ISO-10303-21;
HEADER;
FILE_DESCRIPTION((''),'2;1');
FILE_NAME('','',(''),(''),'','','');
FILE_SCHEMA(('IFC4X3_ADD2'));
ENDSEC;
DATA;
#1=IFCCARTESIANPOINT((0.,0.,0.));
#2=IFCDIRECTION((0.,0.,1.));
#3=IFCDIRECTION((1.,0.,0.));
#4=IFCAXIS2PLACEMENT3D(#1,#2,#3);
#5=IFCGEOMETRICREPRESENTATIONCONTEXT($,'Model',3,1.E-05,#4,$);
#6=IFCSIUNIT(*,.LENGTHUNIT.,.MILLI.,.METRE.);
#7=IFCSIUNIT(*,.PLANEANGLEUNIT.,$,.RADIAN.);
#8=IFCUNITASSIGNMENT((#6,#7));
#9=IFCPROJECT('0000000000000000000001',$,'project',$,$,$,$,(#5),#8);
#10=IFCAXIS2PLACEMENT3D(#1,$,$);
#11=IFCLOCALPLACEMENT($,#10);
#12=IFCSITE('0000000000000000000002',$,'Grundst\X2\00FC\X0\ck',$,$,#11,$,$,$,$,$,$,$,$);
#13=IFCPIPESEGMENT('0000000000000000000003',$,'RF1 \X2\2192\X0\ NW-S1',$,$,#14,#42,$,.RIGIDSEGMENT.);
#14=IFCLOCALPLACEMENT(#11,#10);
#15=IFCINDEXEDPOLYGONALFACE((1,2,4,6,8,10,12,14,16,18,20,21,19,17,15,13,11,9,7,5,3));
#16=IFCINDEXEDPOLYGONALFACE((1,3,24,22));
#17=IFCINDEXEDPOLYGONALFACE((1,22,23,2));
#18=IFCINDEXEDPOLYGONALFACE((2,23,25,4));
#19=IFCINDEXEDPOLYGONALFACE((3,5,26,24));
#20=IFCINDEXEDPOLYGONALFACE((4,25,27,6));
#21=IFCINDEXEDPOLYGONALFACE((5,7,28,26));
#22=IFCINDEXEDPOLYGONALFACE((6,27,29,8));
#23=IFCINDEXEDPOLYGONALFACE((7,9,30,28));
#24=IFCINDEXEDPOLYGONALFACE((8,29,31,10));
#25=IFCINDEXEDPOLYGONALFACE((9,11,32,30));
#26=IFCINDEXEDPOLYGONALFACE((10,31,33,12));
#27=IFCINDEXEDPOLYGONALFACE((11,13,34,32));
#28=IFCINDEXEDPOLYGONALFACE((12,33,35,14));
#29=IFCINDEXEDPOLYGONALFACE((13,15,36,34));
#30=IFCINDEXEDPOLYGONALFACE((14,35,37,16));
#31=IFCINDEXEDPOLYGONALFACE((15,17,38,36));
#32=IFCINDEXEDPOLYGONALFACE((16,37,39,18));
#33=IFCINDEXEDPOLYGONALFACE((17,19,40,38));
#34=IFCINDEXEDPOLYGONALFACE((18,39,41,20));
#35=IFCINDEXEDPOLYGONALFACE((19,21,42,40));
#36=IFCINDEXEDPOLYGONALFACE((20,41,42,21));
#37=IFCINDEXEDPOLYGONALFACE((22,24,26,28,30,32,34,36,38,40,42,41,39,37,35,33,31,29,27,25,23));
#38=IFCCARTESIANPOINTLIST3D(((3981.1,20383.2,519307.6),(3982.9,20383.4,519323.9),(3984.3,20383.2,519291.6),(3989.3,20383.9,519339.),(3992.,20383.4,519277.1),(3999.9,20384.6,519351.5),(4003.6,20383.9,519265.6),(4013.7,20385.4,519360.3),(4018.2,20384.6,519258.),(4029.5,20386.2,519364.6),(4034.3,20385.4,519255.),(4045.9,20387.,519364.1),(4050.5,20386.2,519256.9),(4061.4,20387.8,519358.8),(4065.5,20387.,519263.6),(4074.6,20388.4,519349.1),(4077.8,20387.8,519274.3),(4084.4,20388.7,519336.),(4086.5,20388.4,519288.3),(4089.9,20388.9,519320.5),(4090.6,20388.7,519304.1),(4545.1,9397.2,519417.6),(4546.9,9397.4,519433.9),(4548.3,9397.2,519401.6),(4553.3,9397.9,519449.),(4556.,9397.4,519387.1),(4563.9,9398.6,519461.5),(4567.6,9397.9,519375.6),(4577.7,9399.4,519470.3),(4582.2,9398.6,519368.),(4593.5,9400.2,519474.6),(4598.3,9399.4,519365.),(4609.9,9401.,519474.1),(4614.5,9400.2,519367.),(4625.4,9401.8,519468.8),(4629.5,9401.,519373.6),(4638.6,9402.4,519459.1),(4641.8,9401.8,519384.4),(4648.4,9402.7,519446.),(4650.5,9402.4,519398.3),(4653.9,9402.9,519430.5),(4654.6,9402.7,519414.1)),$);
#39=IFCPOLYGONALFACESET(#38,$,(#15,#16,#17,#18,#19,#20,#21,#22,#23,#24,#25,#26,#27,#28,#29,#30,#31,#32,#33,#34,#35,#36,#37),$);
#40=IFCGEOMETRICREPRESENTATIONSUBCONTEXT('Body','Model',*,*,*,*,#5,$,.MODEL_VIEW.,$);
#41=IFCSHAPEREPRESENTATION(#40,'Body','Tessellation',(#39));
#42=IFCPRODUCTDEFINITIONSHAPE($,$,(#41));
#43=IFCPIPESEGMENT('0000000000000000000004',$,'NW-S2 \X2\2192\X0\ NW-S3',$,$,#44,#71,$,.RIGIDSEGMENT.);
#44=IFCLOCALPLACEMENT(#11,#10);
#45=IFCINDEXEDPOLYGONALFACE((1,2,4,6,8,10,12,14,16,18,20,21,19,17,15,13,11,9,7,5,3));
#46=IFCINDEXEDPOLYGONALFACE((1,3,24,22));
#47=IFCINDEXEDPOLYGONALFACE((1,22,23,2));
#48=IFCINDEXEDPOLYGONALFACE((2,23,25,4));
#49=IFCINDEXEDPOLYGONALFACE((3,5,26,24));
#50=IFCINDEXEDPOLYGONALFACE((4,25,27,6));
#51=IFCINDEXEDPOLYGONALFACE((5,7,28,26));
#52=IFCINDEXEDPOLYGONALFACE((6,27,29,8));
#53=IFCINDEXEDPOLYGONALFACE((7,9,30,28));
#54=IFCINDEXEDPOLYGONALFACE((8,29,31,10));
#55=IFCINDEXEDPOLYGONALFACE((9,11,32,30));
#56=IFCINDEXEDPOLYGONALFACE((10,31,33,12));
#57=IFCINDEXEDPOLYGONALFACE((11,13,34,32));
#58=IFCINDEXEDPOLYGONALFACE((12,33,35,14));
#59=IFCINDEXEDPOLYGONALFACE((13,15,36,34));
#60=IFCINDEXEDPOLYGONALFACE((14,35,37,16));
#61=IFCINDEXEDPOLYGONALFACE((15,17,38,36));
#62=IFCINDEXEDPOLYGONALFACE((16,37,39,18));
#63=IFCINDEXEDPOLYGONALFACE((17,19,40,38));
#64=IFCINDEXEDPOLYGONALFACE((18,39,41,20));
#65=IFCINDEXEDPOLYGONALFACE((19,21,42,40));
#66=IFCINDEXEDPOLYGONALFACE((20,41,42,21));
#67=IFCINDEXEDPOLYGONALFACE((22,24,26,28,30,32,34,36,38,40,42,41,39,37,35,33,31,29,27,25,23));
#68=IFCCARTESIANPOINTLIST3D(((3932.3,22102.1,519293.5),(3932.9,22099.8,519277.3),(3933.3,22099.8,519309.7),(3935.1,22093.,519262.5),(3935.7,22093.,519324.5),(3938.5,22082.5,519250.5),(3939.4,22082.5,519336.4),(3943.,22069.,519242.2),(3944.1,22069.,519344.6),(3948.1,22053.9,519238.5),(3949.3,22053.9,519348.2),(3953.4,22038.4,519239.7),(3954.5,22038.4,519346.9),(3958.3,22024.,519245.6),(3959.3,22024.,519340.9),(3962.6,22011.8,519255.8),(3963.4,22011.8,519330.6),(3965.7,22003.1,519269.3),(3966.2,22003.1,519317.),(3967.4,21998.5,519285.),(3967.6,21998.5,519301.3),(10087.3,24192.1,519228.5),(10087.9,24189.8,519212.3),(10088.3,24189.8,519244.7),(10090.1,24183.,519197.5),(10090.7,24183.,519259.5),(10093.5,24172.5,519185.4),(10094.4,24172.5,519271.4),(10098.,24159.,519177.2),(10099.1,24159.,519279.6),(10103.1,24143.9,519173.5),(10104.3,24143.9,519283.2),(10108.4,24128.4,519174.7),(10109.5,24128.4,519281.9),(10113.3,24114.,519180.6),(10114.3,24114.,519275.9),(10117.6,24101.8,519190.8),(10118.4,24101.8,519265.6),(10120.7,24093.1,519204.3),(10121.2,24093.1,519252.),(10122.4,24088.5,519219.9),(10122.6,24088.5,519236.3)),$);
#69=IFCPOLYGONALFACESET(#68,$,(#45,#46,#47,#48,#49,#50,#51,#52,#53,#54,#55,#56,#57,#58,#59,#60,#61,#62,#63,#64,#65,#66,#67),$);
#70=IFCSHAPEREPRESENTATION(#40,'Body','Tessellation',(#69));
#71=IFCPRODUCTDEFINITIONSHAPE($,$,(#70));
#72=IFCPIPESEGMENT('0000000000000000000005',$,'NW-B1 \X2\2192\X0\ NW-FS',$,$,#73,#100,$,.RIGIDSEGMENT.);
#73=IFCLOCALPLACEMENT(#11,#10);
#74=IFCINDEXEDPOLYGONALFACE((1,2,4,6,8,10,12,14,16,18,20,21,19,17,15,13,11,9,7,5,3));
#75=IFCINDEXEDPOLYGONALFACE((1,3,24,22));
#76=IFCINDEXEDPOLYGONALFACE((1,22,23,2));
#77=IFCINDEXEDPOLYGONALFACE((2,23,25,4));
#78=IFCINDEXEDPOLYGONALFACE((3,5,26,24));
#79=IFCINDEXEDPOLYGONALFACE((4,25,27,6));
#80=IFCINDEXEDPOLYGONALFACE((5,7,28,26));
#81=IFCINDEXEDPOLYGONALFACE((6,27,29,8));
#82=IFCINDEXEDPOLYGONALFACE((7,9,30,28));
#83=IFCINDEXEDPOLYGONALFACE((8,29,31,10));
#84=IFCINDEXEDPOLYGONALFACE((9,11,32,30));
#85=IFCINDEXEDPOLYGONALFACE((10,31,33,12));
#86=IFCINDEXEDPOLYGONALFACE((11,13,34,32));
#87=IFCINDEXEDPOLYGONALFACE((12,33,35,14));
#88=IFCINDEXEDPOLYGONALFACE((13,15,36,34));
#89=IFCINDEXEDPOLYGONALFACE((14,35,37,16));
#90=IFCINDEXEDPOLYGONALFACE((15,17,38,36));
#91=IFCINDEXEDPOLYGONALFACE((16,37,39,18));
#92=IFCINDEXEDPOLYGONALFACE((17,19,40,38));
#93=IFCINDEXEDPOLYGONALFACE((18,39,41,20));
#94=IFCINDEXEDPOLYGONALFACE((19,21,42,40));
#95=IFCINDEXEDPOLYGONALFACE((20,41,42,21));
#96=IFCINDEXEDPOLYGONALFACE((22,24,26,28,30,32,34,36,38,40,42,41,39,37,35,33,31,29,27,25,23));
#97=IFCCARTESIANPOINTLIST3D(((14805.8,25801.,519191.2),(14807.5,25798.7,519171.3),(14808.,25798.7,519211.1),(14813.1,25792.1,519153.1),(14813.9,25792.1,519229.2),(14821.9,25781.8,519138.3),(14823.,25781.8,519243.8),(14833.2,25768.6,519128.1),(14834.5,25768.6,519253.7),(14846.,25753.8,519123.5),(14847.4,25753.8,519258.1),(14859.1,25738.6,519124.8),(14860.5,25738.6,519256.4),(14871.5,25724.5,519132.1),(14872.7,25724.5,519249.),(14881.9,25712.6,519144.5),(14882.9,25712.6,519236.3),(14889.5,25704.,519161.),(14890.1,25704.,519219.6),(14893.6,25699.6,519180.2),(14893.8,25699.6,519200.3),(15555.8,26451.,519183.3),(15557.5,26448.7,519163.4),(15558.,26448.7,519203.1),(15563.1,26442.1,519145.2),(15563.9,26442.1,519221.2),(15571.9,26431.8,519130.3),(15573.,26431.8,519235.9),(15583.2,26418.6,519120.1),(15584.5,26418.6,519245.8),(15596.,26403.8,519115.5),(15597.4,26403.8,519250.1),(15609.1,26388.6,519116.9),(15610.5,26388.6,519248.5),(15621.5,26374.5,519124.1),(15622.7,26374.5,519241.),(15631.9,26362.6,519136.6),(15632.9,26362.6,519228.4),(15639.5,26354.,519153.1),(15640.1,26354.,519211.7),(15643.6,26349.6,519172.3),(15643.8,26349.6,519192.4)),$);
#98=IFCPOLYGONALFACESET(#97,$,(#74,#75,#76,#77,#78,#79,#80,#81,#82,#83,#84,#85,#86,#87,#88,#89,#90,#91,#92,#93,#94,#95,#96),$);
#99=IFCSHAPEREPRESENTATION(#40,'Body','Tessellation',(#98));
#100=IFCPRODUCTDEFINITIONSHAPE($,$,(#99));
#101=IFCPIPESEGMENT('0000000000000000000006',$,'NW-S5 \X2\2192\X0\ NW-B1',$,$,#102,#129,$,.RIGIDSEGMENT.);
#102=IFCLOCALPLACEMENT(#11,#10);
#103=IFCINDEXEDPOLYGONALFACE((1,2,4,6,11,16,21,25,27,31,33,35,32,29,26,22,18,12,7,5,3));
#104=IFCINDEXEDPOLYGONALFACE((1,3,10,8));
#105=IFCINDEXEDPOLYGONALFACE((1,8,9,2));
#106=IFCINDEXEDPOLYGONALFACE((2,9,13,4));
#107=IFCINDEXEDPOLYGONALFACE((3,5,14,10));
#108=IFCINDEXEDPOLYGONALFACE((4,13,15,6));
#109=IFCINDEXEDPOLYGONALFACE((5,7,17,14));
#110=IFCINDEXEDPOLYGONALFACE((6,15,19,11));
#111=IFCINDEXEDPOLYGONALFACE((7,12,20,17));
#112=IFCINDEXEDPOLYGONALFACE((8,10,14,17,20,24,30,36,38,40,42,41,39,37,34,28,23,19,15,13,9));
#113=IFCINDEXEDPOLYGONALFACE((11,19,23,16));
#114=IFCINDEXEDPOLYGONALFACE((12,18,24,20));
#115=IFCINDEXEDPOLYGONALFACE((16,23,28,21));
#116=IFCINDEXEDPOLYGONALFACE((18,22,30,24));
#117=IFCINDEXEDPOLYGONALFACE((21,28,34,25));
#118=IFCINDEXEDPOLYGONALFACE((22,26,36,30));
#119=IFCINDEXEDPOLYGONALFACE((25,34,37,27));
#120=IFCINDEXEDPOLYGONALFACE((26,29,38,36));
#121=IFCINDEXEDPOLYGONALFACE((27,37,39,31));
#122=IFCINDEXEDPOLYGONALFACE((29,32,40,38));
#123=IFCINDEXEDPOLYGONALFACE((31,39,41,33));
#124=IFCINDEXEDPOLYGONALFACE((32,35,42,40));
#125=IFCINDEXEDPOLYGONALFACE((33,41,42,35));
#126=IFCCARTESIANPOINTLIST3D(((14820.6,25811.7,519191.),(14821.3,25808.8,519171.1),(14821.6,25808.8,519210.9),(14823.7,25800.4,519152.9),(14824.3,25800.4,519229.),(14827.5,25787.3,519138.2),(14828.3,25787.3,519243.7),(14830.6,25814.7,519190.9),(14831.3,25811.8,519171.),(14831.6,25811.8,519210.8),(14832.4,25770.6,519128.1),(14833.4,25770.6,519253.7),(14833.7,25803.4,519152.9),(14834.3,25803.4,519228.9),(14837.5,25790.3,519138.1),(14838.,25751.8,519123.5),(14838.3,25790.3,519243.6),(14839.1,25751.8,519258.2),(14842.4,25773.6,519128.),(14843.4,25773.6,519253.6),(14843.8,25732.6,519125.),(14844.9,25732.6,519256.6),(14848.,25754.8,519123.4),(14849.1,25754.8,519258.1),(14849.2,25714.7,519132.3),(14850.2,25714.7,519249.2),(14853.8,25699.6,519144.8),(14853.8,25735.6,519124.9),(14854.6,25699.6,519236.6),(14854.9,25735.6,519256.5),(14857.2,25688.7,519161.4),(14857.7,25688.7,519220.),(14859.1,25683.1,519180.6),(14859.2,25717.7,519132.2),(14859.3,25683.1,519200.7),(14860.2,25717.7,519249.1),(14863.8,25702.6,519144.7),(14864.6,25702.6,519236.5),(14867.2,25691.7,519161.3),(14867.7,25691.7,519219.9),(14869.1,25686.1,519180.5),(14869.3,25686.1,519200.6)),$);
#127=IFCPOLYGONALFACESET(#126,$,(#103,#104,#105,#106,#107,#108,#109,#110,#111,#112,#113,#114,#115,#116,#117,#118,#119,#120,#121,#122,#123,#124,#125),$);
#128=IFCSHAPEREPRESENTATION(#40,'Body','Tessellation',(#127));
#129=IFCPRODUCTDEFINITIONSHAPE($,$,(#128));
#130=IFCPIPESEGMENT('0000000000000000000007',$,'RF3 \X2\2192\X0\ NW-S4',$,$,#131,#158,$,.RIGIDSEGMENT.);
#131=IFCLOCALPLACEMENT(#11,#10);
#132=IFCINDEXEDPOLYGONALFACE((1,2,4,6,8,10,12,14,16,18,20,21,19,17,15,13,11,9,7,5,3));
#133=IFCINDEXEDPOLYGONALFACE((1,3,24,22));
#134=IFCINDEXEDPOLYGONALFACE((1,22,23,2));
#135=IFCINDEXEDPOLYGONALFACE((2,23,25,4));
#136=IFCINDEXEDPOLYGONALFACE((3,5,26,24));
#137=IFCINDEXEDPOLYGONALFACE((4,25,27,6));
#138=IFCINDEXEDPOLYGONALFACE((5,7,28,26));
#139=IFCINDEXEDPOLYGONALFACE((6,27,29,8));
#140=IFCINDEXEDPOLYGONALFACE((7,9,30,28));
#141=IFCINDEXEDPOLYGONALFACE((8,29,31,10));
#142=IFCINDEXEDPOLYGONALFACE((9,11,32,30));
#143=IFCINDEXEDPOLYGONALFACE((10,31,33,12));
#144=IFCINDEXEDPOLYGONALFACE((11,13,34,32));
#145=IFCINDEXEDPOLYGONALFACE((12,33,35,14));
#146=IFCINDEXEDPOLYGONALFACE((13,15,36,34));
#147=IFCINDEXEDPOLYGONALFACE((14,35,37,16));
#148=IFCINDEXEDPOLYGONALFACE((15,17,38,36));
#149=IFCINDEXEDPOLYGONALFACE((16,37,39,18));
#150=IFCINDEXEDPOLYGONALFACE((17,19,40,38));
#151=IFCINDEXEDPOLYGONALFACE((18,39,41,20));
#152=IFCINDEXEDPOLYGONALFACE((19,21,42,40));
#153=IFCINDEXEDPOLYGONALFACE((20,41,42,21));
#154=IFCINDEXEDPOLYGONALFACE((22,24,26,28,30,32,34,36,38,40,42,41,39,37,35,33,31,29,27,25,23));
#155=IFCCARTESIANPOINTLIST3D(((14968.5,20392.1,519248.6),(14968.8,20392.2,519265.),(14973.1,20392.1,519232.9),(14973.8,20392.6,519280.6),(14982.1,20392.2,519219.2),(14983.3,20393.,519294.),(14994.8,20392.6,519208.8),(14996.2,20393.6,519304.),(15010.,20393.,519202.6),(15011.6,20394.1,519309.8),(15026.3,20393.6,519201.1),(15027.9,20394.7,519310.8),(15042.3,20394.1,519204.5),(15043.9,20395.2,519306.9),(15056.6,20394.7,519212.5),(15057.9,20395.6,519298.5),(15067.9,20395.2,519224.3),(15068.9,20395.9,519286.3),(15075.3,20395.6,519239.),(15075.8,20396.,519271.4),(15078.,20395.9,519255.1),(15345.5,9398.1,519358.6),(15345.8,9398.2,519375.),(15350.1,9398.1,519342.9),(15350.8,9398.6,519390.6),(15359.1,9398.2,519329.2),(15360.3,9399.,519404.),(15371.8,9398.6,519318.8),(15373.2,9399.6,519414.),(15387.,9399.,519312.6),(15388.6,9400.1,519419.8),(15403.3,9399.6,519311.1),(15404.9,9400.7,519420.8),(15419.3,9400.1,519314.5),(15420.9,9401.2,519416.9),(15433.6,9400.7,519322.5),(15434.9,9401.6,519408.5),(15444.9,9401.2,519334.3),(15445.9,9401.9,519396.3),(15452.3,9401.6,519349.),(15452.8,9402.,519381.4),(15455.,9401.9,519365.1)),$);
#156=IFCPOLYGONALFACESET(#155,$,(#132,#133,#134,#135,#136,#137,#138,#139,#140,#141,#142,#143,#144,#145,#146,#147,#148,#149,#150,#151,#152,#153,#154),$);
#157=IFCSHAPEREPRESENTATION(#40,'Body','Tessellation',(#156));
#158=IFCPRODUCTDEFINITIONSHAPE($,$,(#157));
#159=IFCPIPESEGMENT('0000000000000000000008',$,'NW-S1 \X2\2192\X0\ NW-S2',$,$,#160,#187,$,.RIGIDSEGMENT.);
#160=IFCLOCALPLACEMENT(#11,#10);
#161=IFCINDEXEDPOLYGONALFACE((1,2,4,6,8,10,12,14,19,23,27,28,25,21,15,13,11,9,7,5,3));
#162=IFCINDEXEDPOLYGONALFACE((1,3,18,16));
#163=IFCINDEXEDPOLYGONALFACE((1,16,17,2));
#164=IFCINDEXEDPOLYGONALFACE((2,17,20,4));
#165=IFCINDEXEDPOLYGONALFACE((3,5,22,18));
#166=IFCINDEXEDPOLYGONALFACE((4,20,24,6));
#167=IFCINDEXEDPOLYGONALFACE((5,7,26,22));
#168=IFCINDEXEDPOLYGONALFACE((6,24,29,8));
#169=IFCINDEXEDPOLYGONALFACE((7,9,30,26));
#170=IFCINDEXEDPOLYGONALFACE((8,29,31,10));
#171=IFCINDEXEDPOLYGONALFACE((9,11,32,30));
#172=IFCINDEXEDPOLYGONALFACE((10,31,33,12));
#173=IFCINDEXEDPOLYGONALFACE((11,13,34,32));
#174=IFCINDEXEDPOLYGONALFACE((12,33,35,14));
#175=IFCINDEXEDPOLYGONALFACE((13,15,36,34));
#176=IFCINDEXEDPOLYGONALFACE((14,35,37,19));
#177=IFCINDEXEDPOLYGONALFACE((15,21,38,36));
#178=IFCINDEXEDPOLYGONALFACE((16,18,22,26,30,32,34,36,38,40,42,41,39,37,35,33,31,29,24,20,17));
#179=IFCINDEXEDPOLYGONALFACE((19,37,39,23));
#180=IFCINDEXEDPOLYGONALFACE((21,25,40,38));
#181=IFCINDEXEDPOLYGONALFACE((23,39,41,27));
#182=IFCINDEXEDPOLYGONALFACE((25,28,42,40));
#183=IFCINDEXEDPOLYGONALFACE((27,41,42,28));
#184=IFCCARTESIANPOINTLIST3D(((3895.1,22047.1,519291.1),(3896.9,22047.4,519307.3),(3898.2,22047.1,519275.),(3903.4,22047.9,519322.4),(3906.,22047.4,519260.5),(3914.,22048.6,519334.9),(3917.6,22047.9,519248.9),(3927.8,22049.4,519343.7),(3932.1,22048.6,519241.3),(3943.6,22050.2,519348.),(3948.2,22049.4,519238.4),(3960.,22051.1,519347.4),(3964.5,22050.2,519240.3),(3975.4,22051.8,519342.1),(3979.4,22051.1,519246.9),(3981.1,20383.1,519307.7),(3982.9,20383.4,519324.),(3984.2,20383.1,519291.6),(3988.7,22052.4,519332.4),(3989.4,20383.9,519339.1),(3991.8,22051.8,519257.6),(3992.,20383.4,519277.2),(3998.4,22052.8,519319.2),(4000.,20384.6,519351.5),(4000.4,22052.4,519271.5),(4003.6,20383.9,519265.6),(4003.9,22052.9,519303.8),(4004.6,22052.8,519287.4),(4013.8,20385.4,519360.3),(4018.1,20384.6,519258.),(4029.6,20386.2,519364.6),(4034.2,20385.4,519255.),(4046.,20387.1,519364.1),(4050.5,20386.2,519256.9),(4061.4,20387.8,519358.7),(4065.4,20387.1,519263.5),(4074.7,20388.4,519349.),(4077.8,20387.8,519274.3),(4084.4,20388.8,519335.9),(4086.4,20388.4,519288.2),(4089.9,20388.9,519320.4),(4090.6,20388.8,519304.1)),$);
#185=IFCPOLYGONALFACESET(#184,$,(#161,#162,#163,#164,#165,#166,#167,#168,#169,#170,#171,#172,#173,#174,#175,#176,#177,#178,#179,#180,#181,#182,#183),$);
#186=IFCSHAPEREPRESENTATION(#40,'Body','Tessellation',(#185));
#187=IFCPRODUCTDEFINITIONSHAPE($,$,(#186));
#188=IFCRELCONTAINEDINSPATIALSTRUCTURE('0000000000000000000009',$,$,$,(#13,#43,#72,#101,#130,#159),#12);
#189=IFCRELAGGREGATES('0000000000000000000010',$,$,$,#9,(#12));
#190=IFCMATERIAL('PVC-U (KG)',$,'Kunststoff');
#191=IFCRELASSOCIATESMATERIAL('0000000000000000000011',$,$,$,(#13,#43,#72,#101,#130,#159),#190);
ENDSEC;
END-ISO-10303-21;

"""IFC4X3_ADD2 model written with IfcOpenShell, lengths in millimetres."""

from ifc_helpers import new_model, si_unit, frame, origin, origin_with_axes, place, context, subcontext, project, spatial, circle, extrude, material, element, save


model = new_model("IFC4X3_ADD2")

# Units and contexts
model_context = context("Model", 3, precision=1e-05, world=origin_with_axes())
body_context = subcontext(model_context, "Body", "Model", "MODEL_VIEW")
ifc_project = project(units=[si_unit("LENGTHUNIT", "METRE", prefix="MILLI"), si_unit("PLANEANGLEUNIT", "RADIAN")], contexts=[model_context])

# Site
site_placement = place(None, origin())
site = spatial("IfcSite", under=ifc_project, at=site_placement, Name="Grundstück")

# Shared definitions
ifc_material = material(Name="PVC-U (KG)", Category="Kunststoff")

# Pipe segments
pipe_segment_1_placement = place(site_placement, frame((4600.0, 9400.0, 519365.0)))
element("IfcPipeSegment", 1, at=pipe_segment_1_placement, inside=site, material=ifc_material, Name="RF1 → NW-S1", PredefinedType="RIGIDSEGMENT", context=body_context, shape_type="SweptSolid", body=[
    extrude(circle(Radius=55.0), frame((0.0, 0.0, 55.0), z_axis=(-0.051268, 0.998635, -0.01), x_axis=(0.0, 1.0, 0.0)), (0.0, 0.0, 1.0), 11001.0),
])
pipe_segment_2_placement = place(site_placement, frame((3950.0, 22050.0, 519238.3)))
element("IfcPipeSegment", 2, at=pipe_segment_2_placement, inside=site, material=ifc_material, Name="NW-S2 → NW-S3", PredefinedType="RIGIDSEGMENT", context=body_context, shape_type="SweptSolid", body=[
    extrude(circle(Radius=55.0), frame((0.0, 0.0, 55.0), z_axis=(0.946852, 0.321514, -0.01), x_axis=(0.0, 1.0, 0.0)), (0.0, 0.0, 1.0), 6500.5),
])
pipe_segment_3_placement = place(site_placement, frame((14850.0, 25750.0, 519123.2)))
element("IfcPipeSegment", 3, at=pipe_segment_3_placement, inside=site, material=ifc_material, Name="NW-B1 → NW-FS", PredefinedType="RIGIDSEGMENT", context=body_context, shape_type="SweptSolid", body=[
    extrude(circle(Radius=67.5), frame((0.0, 0.0, 67.5), z_axis=(0.755665, 0.65491, -0.008), x_axis=(0.0, 1.0, 0.0)), (0.0, 0.0, 1.0), 992.5),
])
pipe_segment_4_placement = place(site_placement, frame((14840.0, 25747.0, 519123.3)))
element("IfcPipeSegment", 4, at=pipe_segment_4_placement, inside=site, material=ifc_material, Name="NW-S5 → NW-B1", PredefinedType="RIGIDSEGMENT", context=body_context, shape_type="SweptSolid", body=[
    extrude(circle(Radius=67.5), frame((0.0, 0.0, 67.5), z_axis=(0.957796, 0.287339, -0.008), x_axis=(0.0, 1.0, 0.0)), (0.0, 0.0, 1.0), 10.4),
])
pipe_segment_5_placement = place(site_placement, frame((15400.0, 9400.0, 519311.0)))
element("IfcPipeSegment", 5, at=pipe_segment_5_placement, inside=site, material=ifc_material, Name="RF3 → NW-S4", PredefinedType="RIGIDSEGMENT", context=body_context, shape_type="SweptSolid", body=[
    extrude(circle(Radius=55.0), frame((0.0, 0.0, 55.0), z_axis=(-0.03427, 0.999363, -0.01), x_axis=(0.0, 1.0, 0.0)), (0.0, 0.0, 1.0), 11001.0),
])
pipe_segment_6_placement = place(site_placement, frame((4036.0, 20386.0, 519255.0)))
element("IfcPipeSegment", 6, at=pipe_segment_6_placement, inside=site, material=ifc_material, Name="NW-S1 → NW-S2", PredefinedType="RIGIDSEGMENT", context=body_context, shape_type="SweptSolid", body=[
    extrude(circle(Radius=55.0), frame((0.0, 0.0, 55.0), z_axis=(-0.051611, 0.998617, -0.01), x_axis=(0.0, 1.0, 0.0)), (0.0, 0.0, 1.0), 1666.3),
])

save(model, "model.ifc")
